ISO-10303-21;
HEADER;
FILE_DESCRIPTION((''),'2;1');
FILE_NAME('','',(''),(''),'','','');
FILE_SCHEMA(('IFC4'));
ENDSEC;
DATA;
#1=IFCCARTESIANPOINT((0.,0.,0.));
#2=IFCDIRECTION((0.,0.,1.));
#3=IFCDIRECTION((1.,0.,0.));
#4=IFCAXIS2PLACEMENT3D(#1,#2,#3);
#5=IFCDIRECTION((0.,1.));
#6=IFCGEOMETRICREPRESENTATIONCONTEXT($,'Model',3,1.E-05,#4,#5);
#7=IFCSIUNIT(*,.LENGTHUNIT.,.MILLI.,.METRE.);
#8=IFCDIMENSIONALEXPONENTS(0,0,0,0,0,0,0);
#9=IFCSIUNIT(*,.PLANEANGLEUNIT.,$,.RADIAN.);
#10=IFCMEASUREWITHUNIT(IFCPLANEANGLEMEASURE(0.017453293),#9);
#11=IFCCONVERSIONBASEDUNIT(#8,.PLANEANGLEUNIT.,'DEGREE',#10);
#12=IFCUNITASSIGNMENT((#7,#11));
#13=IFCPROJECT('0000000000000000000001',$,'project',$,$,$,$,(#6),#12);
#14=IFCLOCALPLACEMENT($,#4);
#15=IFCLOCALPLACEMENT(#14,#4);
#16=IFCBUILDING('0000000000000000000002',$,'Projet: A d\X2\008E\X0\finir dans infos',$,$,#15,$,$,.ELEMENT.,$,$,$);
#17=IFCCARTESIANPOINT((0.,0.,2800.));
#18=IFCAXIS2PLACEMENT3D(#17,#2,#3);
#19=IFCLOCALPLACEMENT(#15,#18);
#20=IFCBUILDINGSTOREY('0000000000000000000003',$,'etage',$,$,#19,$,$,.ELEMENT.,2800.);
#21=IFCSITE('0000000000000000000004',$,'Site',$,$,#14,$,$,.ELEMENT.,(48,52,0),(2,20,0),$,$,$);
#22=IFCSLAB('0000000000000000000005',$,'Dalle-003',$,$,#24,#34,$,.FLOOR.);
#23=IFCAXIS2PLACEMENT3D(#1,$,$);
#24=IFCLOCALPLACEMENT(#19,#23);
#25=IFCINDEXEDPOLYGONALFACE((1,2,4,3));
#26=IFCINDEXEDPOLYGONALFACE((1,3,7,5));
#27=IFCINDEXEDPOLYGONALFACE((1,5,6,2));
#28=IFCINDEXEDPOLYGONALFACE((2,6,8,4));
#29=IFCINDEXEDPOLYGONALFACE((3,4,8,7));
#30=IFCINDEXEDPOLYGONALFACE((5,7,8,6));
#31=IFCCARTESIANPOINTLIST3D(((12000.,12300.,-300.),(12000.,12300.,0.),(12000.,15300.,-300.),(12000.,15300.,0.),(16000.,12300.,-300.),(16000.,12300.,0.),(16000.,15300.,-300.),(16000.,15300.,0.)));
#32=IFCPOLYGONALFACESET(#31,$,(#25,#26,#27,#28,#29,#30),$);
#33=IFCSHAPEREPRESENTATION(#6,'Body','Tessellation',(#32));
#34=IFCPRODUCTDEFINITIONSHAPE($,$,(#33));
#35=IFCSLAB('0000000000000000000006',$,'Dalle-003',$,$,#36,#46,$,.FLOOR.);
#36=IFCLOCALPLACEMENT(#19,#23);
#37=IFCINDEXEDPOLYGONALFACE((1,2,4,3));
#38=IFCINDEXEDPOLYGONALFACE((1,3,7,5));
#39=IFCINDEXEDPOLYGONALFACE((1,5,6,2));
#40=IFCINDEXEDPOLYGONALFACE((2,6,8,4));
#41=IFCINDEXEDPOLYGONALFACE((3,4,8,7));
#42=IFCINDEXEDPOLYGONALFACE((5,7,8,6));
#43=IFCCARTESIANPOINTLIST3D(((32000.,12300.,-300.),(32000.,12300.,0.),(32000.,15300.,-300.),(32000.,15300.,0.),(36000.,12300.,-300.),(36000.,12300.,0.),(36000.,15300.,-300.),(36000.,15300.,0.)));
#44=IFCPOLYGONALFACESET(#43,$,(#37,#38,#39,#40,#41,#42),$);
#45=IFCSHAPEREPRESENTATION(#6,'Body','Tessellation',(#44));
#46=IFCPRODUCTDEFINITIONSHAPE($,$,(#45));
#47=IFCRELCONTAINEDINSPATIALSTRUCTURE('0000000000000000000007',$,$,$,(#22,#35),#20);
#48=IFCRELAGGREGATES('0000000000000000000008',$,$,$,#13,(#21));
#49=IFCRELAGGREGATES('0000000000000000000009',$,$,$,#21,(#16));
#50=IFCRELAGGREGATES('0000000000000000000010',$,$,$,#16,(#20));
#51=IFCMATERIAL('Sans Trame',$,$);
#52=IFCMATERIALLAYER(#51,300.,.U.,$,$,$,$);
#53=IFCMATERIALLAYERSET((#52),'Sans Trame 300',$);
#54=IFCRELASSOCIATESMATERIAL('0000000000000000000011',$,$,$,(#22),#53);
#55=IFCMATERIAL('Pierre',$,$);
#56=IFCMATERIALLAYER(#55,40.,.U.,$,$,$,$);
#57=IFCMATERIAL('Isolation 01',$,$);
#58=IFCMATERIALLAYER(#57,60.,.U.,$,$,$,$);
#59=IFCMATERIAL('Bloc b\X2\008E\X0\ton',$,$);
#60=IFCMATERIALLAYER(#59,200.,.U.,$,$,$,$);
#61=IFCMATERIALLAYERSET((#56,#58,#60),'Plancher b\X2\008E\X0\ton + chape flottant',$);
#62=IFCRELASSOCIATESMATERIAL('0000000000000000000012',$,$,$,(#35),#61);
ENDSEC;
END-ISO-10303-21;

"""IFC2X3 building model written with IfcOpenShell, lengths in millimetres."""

from ifc_helpers import new_model, entity, si_unit, converted_unit, direction, frame, origin_with_axes, place, context, project, spatial, polyline, outline, extrude, material, layer, layer_set, layer_usage, element, save


model = new_model("IFC2X3")

# Units and contexts
model_context = context("Model", 3, precision=1e-05, world=origin_with_axes(), true_north=direction((0.0, 1.0)))
ifc_project = project(units=[si_unit("LENGTHUNIT", "METRE", prefix="MILLI"), converted_unit("PLANEANGLEUNIT", "DEGREE", entity("IfcPlaneAngleMeasure", 0.017453293), si_unit("PLANEANGLEUNIT", "RADIAN"), dimensions=[0, 0, 0, 0, 0, 0, 0])], contexts=[model_context])

# Site, building, storey
site_placement = place(None, origin_with_axes())
site = spatial("IfcSite", under=ifc_project, at=site_placement, Name="Site", CompositionType="ELEMENT", RefLatitude=(48, 52, 0), RefLongitude=(2, 20, 0))
building_placement = place(site_placement, origin_with_axes())
building = spatial("IfcBuilding", under=site, at=building_placement, Name="Projet: A d\u008efinir dans infos", CompositionType="ELEMENT")
storey_placement = place(building_placement, frame((0.0, 0.0, 2800.0), z_axis=(0.0, 0.0, 1.0), x_axis=(1.0, 0.0, 0.0)))
storey = spatial("IfcBuildingStorey", under=building, at=storey_placement, Name="etage", CompositionType="ELEMENT", Elevation=2800.0)

# Slabs
ifc_material_1 = material(Name="Sans Trame")
ifc_layer_1 = layer(ifc_material_1, 300.0, ventilated="UNKNOWN")
ifc_layer_set_1 = layer_set([ifc_layer_1], Name="Sans Trame 300")
ifc_layer_usage_1 = layer_usage(ifc_layer_set_1, "AXIS3", "NEGATIVE", 300.0)
slab_1_placement = place(storey_placement, frame((12000.0, 15300.0, -300.0), z_axis=(0.0, 0.0, 1.0), x_axis=(1.0, 0.0, 0.0)))
element("IfcSlab", 1, at=slab_1_placement, inside=storey, material=ifc_layer_usage_1, Name="Dalle-003", PredefinedType="FLOOR", context=model_context, shape_type="SweptSolid", body=[
    extrude(outline(polyline([(0.0, 0.0), (0.0, -3000.0), (4000.0, -3000.0), (4000.0, 0.0), (0.0, 0.0)])), origin_with_axes(), (0.0, 0.0, 1.0), 300.0),
])
ifc_material_2 = material(Name="Pierre")
ifc_layer_2 = layer(ifc_material_2, 40.0, ventilated="UNKNOWN")
ifc_material_3 = material(Name="Isolation 01")
ifc_layer_3 = layer(ifc_material_3, 60.0, ventilated="UNKNOWN")
ifc_material_4 = material(Name="Bloc b\u008eton")
ifc_layer_4 = layer(ifc_material_4, 200.0, ventilated="UNKNOWN")
ifc_layer_set_2 = layer_set([ifc_layer_2, ifc_layer_3, ifc_layer_4], Name="Plancher b\u008eton + chape flottant")
ifc_layer_usage_2 = layer_usage(ifc_layer_set_2, "AXIS3", "NEGATIVE", 300.0)
slab_2_placement = place(storey_placement, frame((32000.0, 15300.0, -300.0), z_axis=(0.0, 0.0, 1.0), x_axis=(1.0, 0.0, 0.0)))
element("IfcSlab", 2, at=slab_2_placement, inside=storey, material=ifc_layer_usage_2, Name="Dalle-003", PredefinedType="FLOOR", context=model_context, shape_type="SweptSolid", body=[
    extrude(outline(polyline([(0.0, 0.0), (0.0, -3000.0), (4000.0, -3000.0), (4000.0, 0.0), (0.0, 0.0)])), origin_with_axes(), (0.0, 0.0, 1.0), 300.0),
])

save(model, "model.ifc")
